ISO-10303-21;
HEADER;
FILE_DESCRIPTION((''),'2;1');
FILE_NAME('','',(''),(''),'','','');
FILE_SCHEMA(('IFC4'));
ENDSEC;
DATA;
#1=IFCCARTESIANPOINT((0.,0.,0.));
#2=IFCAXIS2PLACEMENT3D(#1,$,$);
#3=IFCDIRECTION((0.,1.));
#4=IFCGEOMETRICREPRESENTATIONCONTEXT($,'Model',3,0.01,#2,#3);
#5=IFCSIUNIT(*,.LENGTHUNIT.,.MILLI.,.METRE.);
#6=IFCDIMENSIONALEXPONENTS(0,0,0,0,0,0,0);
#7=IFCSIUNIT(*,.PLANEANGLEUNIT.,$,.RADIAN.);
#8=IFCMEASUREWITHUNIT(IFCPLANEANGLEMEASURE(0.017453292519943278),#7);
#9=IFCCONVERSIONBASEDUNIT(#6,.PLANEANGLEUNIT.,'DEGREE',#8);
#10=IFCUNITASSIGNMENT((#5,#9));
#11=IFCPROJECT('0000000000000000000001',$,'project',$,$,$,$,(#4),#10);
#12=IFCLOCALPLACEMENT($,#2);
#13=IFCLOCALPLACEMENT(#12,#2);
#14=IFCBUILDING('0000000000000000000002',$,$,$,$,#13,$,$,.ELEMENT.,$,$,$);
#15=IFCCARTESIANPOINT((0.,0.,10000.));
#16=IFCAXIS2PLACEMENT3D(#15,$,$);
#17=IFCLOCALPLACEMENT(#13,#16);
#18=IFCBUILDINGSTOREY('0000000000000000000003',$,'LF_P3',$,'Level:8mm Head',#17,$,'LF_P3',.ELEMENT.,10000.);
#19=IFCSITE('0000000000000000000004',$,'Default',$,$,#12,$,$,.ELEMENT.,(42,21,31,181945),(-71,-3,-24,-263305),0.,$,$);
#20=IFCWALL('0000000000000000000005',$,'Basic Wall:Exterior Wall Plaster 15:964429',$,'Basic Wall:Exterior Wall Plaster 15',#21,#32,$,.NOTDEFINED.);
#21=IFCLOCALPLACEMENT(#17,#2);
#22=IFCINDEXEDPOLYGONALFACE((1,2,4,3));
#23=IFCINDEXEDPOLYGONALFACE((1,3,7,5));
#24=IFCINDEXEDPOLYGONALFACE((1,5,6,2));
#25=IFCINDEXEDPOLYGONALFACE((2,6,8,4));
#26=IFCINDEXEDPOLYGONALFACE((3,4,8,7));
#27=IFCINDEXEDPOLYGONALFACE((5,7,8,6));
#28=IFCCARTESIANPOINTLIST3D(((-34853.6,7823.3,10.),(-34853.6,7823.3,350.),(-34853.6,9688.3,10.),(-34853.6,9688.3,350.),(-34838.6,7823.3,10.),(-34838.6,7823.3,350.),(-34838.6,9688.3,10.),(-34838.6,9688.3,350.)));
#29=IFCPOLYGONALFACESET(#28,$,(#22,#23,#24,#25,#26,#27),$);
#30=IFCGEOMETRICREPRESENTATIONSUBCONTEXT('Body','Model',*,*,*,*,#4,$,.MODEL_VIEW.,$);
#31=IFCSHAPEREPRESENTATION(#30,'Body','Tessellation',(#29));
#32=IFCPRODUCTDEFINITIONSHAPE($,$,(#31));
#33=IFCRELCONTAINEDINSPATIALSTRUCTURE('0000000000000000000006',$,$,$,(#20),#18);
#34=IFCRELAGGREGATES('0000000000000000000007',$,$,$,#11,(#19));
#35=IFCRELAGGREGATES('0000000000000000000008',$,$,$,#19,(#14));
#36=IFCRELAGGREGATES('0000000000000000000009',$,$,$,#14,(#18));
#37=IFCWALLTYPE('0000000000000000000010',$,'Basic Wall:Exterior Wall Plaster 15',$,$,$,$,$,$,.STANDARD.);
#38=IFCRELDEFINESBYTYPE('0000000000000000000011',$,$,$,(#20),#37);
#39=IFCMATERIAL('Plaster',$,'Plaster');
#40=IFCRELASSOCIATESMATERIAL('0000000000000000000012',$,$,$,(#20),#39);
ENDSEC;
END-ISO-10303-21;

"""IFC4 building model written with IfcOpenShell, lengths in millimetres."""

from ifc_helpers import new_model, entity, si_unit, converted_unit, direction, frame, origin, place, context, subcontext, project, spatial, indexed_curve, outline, extrude, material, type_object, element, save


model = new_model("IFC4")

# Units and contexts
model_context = context("Model", 3, precision=0.01, world=origin(), true_north=direction((0.0, 1.0)))
body_context = subcontext(model_context, "Body", "Model", "MODEL_VIEW")
ifc_project = project(units=[si_unit("LENGTHUNIT", "METRE", prefix="MILLI"), converted_unit("PLANEANGLEUNIT", "DEGREE", entity("IfcPlaneAngleMeasure", 0.017453292519943278), si_unit("PLANEANGLEUNIT", "RADIAN"), dimensions=[0, 0, 0, 0, 0, 0, 0])], contexts=[model_context])

# Site, building, storey
site_placement = place(None, origin())
site = spatial("IfcSite", under=ifc_project, at=site_placement, Name="Default", CompositionType="ELEMENT", RefLatitude=(42, 21, 31, 181945), RefLongitude=(-71, -3, -24, -263305), RefElevation=0.0)
building_placement = place(site_placement, origin())
building = spatial("IfcBuilding", under=site, at=building_placement, CompositionType="ELEMENT")
storey_placement = place(building_placement, frame((0.0, 0.0, 10000.0)))
storey = spatial("IfcBuildingStorey", under=building, at=storey_placement, Name="LF_P3", ObjectType="Level:8mm Head", LongName="LF_P3", CompositionType="ELEMENT", Elevation=10000.0)

# Wall
ifc_material_1 = material(Name="Plaster", Category="Plaster")
wall_type_1 = type_object("IfcWallType", Name="Basic Wall:Exterior Wall Plaster 15", PredefinedType="STANDARD")
wall_1_placement = place(storey_placement, frame((-34846.1, 7823.3, 10.0), z_axis=(0.0, 0.0, 1.0), x_axis=(0.0, 1.0, 0.0)))
element("IfcWall", 1, at=wall_1_placement, inside=storey, type_object=wall_type_1, material=ifc_material_1, Name="Basic Wall:Exterior Wall Plaster 15:964429", ObjectType="Basic Wall:Exterior Wall Plaster 15", PredefinedType="NOTDEFINED", context=body_context, shape_type="SweptSolid", body=[
    extrude(outline(indexed_curve([(1865.0, 7.5), (0.0, 7.5), (0.0, -7.5), (1865.0, -7.5), (1865.0, 7.5)], self_intersect=False)), origin(), (0.0, 0.0, 1.0), 340.0),
])

save(model, "model.ifc")
